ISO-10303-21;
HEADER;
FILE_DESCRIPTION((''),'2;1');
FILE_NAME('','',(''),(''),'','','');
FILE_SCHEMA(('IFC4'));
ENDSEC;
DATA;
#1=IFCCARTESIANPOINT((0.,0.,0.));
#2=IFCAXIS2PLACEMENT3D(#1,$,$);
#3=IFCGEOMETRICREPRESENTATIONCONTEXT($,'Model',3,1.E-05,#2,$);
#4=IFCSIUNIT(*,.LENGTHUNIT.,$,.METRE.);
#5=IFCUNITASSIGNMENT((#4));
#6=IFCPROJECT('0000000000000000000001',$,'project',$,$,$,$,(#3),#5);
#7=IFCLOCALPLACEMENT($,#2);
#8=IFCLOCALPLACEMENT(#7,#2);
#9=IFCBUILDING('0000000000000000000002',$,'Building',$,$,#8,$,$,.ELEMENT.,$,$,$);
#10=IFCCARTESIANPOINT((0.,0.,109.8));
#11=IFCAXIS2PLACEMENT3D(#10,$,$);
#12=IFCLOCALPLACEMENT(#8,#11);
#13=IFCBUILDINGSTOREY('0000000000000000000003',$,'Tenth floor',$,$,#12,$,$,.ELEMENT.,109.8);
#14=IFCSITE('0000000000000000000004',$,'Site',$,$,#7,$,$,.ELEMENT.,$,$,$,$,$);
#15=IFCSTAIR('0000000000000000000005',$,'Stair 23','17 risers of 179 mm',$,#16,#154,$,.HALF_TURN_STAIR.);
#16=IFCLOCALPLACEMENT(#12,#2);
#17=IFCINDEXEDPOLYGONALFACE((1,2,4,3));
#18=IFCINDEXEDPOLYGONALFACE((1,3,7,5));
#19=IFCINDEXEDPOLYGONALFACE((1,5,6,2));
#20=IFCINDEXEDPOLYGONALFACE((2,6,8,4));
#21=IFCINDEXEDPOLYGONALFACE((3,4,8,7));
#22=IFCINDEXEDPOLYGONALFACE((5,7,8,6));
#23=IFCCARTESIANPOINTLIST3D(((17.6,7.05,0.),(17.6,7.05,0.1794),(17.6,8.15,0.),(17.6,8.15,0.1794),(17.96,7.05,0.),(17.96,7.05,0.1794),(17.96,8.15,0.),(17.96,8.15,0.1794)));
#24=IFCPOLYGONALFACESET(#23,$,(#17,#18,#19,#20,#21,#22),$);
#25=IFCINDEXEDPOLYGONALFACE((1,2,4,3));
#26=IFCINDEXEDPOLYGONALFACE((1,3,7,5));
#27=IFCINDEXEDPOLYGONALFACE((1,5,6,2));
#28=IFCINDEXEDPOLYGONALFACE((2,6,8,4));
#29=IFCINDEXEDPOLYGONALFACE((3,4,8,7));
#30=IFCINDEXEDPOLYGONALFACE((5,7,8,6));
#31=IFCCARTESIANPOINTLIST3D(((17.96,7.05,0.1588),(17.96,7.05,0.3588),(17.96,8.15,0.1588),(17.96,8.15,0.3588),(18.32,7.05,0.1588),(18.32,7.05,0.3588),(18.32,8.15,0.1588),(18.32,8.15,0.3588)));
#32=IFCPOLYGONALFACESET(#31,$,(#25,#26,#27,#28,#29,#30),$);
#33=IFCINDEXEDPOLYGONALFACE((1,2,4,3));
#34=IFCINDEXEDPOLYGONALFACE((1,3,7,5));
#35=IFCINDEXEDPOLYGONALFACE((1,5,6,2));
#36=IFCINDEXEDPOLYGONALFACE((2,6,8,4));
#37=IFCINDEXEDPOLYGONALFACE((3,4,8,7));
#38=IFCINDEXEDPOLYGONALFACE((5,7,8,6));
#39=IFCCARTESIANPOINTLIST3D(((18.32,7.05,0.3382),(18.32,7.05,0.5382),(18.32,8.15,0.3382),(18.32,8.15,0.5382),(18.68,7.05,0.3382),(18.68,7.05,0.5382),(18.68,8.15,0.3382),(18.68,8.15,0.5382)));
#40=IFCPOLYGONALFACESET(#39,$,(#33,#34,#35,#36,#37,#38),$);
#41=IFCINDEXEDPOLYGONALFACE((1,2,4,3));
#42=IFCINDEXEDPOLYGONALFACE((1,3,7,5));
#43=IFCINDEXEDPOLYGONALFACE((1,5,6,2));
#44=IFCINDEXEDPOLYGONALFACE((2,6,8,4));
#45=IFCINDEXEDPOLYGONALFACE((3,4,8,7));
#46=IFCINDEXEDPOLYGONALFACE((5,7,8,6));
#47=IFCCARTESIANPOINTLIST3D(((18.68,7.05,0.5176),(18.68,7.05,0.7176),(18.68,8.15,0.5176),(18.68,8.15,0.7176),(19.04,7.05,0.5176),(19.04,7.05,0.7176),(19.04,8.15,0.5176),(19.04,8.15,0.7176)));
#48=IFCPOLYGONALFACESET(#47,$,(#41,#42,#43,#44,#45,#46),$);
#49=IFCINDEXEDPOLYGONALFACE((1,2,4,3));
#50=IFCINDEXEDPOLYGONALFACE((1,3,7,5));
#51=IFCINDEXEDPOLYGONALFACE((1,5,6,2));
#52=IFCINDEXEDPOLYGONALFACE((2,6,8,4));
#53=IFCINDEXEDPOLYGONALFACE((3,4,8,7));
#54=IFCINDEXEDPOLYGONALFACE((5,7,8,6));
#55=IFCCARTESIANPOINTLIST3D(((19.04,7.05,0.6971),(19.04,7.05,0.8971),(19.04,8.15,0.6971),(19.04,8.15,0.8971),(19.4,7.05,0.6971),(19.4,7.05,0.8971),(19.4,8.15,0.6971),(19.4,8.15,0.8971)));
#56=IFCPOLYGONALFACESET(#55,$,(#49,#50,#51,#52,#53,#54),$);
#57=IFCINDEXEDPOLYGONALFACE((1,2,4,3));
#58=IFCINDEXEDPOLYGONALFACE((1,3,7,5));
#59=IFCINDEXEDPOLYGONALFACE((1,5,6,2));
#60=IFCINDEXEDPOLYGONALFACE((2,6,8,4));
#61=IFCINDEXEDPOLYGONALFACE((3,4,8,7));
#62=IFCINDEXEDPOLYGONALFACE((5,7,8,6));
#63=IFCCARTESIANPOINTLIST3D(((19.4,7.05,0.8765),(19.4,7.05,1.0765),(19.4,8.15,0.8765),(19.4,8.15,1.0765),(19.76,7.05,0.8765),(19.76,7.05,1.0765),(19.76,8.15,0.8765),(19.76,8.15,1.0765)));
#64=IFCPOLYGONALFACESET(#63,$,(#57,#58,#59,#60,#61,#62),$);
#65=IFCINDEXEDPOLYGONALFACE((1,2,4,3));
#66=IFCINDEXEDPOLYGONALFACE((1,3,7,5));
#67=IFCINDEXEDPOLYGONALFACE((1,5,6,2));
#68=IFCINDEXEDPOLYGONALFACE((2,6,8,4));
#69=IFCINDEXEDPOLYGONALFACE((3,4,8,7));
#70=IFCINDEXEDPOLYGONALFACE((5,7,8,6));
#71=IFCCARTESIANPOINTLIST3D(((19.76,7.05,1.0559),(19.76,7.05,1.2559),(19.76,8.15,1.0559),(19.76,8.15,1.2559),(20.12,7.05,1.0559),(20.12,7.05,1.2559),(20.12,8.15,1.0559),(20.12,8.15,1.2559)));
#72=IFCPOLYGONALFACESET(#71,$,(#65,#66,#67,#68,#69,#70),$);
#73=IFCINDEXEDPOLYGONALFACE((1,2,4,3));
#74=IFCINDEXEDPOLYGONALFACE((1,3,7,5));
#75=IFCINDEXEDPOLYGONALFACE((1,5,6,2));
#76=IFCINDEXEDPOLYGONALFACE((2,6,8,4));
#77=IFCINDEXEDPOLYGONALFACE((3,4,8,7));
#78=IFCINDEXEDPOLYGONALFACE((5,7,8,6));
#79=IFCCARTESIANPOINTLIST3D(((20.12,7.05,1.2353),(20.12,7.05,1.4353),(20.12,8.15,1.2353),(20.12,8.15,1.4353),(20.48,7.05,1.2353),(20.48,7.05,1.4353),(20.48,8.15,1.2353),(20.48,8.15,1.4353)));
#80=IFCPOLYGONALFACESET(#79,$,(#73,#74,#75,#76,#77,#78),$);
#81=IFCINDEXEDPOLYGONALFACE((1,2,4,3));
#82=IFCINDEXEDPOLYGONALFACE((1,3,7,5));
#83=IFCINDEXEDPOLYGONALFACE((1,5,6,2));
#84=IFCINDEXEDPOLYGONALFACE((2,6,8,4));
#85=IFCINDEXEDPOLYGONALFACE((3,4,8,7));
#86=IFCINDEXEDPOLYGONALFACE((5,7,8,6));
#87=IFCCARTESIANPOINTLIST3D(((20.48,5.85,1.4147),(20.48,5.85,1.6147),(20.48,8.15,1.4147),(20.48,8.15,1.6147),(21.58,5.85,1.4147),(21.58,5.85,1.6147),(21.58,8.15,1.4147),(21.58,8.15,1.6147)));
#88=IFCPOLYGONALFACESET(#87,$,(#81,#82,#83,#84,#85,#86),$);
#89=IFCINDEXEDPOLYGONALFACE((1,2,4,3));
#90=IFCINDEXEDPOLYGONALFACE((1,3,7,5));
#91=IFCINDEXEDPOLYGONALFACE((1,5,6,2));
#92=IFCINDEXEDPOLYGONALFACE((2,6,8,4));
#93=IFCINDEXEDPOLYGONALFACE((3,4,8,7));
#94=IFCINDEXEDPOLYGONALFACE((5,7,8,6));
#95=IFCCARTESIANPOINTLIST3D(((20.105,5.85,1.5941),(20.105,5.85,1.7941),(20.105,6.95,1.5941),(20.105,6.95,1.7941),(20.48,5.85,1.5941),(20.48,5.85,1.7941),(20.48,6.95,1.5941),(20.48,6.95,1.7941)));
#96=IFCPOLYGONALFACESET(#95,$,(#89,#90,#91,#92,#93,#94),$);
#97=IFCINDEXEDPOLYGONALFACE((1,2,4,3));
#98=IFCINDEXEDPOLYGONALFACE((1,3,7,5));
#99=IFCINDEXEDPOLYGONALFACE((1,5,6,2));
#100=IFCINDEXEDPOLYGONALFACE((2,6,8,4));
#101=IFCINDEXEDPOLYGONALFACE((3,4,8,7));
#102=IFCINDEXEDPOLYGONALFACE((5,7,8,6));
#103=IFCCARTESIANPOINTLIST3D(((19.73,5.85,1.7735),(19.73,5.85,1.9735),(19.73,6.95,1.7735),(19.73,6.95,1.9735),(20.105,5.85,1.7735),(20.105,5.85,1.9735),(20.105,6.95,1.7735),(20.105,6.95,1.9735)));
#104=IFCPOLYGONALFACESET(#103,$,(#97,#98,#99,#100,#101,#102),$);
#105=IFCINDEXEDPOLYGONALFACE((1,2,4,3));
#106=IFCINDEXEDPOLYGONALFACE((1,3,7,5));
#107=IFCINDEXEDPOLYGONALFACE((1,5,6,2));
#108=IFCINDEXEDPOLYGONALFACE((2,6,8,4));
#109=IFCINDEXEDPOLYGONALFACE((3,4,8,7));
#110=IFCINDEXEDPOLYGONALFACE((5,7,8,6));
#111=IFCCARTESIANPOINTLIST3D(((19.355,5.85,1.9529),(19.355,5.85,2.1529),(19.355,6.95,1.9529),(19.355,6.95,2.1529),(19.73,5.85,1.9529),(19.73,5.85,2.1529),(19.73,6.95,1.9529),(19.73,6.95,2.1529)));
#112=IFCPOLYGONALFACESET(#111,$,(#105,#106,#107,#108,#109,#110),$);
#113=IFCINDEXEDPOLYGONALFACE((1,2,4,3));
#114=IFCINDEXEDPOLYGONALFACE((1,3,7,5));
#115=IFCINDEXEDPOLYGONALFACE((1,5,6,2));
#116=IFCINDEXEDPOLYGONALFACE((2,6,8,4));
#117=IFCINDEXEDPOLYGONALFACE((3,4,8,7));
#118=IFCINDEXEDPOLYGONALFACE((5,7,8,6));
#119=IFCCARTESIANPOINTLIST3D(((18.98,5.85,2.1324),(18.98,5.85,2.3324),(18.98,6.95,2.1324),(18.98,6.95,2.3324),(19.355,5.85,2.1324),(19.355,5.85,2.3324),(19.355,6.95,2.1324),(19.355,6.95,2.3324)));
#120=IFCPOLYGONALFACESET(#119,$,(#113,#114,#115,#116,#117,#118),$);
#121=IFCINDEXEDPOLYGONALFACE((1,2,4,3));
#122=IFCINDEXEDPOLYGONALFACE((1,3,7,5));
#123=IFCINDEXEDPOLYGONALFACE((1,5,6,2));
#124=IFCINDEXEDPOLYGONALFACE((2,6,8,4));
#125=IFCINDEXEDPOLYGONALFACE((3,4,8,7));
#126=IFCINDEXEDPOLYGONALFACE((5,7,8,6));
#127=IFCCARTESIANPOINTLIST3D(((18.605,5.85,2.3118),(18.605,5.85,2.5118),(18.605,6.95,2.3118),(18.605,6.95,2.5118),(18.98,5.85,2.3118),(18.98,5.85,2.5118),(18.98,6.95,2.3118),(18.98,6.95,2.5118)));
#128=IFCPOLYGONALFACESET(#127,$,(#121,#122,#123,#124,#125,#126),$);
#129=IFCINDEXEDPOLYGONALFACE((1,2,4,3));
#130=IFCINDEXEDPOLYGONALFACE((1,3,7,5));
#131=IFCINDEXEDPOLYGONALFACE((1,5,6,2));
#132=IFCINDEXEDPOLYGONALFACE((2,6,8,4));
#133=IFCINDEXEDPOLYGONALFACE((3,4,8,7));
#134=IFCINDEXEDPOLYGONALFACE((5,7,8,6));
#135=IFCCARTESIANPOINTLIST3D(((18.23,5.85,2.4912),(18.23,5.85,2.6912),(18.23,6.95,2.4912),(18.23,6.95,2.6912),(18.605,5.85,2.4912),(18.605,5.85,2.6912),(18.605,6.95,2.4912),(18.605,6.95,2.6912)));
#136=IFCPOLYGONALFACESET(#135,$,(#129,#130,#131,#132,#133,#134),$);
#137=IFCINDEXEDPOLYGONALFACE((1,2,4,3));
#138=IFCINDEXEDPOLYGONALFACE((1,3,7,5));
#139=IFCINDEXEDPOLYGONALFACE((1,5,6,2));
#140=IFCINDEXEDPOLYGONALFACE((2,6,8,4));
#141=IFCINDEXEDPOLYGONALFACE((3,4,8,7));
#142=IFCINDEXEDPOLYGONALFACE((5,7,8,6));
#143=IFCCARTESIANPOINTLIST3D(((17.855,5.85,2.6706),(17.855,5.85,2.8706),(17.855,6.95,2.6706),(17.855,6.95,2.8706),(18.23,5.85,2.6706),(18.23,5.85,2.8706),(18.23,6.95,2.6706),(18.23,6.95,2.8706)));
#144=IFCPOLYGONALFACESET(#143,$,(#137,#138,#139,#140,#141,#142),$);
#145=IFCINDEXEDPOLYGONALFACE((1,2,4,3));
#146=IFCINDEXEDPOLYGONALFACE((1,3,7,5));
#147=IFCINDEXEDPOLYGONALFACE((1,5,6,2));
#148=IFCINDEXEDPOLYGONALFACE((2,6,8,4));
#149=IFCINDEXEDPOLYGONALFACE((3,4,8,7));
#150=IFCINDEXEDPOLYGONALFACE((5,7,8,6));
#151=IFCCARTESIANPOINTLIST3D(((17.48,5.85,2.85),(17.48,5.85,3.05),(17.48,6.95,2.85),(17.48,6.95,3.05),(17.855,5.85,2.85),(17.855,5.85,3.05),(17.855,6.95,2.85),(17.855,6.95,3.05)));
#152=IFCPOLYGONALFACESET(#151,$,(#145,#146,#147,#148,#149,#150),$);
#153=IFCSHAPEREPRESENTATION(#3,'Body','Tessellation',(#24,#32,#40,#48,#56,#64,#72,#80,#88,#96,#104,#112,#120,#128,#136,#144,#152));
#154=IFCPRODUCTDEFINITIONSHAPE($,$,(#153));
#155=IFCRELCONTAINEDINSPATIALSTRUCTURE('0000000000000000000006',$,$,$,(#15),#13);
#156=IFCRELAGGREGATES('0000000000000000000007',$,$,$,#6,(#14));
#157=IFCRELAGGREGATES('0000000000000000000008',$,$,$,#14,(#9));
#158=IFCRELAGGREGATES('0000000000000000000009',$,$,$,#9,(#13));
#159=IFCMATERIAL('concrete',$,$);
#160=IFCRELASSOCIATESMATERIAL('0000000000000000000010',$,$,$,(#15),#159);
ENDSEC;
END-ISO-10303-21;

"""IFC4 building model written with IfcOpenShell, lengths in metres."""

from ifc_helpers import new_model, si_unit, frame, origin, place, context, project, spatial, polyline, outline, extrude, material, element, save


model = new_model("IFC4")

# Units and contexts
model_context = context("Model", 3, precision=1e-05, world=origin())
ifc_project = project(units=[si_unit("LENGTHUNIT", "METRE")], contexts=[model_context])

# Site, building, storey
site_placement = place(None, origin())
site = spatial("IfcSite", under=ifc_project, at=site_placement, Name="Site", CompositionType="ELEMENT")
building_placement = place(site_placement, origin())
building = spatial("IfcBuilding", under=site, at=building_placement, Name="Building", CompositionType="ELEMENT")
storey_placement = place(building_placement, frame((0.0, 0.0, 109.8)))
storey = spatial("IfcBuildingStorey", under=building, at=storey_placement, Name="Tenth floor", CompositionType="ELEMENT", Elevation=109.8)

# Shared definitions
ifc_material = material(Name="concrete")

# Stair
stair_1_placement = place(storey_placement, frame((17.6, 7.6, 0.0), z_axis=(0.0, 0.0, 1.0), x_axis=(1.0, 0.0, 0.0)))
element("IfcStair", 1, at=stair_1_placement, inside=storey, material=ifc_material, Name="Stair 23", Description="17 risers of 179 mm", PredefinedType="HALF_TURN_STAIR", context=model_context, shape_type="SweptSolid", body=[
    extrude(outline(polyline([(0.0, -0.55), (0.36, -0.55), (0.36, 0.55), (0.0, 0.55), (0.0, -0.55)])), origin(), (0.0, 0.0, 1.0), 0.1794),
    extrude(outline(polyline([(0.36, -0.55), (0.72, -0.55), (0.72, 0.55), (0.36, 0.55), (0.36, -0.55)])), frame((0.0, 0.0, 0.1588)), (0.0, 0.0, 1.0), 0.2),
    extrude(outline(polyline([(0.72, -0.55), (1.08, -0.55), (1.08, 0.55), (0.72, 0.55), (0.72, -0.55)])), frame((0.0, 0.0, 0.3382)), (0.0, 0.0, 1.0), 0.2),
    extrude(outline(polyline([(1.08, -0.55), (1.44, -0.55), (1.44, 0.55), (1.08, 0.55), (1.08, -0.55)])), frame((0.0, 0.0, 0.5176)), (0.0, 0.0, 1.0), 0.2),
    extrude(outline(polyline([(1.44, -0.55), (1.8, -0.55), (1.8, 0.55), (1.44, 0.55), (1.44, -0.55)])), frame((0.0, 0.0, 0.6971)), (0.0, 0.0, 1.0), 0.2),
    extrude(outline(polyline([(1.8, -0.55), (2.16, -0.55), (2.16, 0.55), (1.8, 0.55), (1.8, -0.55)])), frame((0.0, 0.0, 0.8765)), (0.0, 0.0, 1.0), 0.2),
    extrude(outline(polyline([(2.16, -0.55), (2.52, -0.55), (2.52, 0.55), (2.16, 0.55), (2.16, -0.55)])), frame((0.0, 0.0, 1.0559)), (0.0, 0.0, 1.0), 0.2),
    extrude(outline(polyline([(2.52, -0.55), (2.88, -0.55), (2.88, 0.55), (2.52, 0.55), (2.52, -0.55)])), frame((0.0, 0.0, 1.2353)), (0.0, 0.0, 1.0), 0.2),
    extrude(outline(polyline([(2.88, -1.75), (3.98, -1.75), (3.98, 0.55), (2.88, 0.55), (2.88, -1.75)])), frame((0.0, 0.0, 1.4147)), (0.0, 0.0, 1.0), 0.2),
    extrude(outline(polyline([(2.505, -1.75), (2.88, -1.75), (2.88, -0.65), (2.505, -0.65), (2.505, -1.75)])), frame((0.0, 0.0, 1.5941)), (0.0, 0.0, 1.0), 0.2),
    extrude(outline(polyline([(2.13, -1.75), (2.505, -1.75), (2.505, -0.65), (2.13, -0.65), (2.13, -1.75)])), frame((0.0, 0.0, 1.7735)), (0.0, 0.0, 1.0), 0.2),
    extrude(outline(polyline([(1.755, -1.75), (2.13, -1.75), (2.13, -0.65), (1.755, -0.65), (1.755, -1.75)])), frame((0.0, 0.0, 1.9529)), (0.0, 0.0, 1.0), 0.2),
    extrude(outline(polyline([(1.38, -1.75), (1.755, -1.75), (1.755, -0.65), (1.38, -0.65), (1.38, -1.75)])), frame((0.0, 0.0, 2.1324)), (0.0, 0.0, 1.0), 0.2),
    extrude(outline(polyline([(1.005, -1.75), (1.38, -1.75), (1.38, -0.65), (1.005, -0.65), (1.005, -1.75)])), frame((0.0, 0.0, 2.3118)), (0.0, 0.0, 1.0), 0.2),
    extrude(outline(polyline([(0.63, -1.75), (1.005, -1.75), (1.005, -0.65), (0.63, -0.65), (0.63, -1.75)])), frame((0.0, 0.0, 2.4912)), (0.0, 0.0, 1.0), 0.2),
    extrude(outline(polyline([(0.255, -1.75), (0.63, -1.75), (0.63, -0.65), (0.255, -0.65), (0.255, -1.75)])), frame((0.0, 0.0, 2.6706)), (0.0, 0.0, 1.0), 0.2),
    extrude(outline(polyline([(-0.12, -1.75), (0.255, -1.75), (0.255, -0.65), (-0.12, -0.65), (-0.12, -1.75)])), frame((0.0, 0.0, 2.85)), (0.0, 0.0, 1.0), 0.2),
])

save(model, "model.ifc")
